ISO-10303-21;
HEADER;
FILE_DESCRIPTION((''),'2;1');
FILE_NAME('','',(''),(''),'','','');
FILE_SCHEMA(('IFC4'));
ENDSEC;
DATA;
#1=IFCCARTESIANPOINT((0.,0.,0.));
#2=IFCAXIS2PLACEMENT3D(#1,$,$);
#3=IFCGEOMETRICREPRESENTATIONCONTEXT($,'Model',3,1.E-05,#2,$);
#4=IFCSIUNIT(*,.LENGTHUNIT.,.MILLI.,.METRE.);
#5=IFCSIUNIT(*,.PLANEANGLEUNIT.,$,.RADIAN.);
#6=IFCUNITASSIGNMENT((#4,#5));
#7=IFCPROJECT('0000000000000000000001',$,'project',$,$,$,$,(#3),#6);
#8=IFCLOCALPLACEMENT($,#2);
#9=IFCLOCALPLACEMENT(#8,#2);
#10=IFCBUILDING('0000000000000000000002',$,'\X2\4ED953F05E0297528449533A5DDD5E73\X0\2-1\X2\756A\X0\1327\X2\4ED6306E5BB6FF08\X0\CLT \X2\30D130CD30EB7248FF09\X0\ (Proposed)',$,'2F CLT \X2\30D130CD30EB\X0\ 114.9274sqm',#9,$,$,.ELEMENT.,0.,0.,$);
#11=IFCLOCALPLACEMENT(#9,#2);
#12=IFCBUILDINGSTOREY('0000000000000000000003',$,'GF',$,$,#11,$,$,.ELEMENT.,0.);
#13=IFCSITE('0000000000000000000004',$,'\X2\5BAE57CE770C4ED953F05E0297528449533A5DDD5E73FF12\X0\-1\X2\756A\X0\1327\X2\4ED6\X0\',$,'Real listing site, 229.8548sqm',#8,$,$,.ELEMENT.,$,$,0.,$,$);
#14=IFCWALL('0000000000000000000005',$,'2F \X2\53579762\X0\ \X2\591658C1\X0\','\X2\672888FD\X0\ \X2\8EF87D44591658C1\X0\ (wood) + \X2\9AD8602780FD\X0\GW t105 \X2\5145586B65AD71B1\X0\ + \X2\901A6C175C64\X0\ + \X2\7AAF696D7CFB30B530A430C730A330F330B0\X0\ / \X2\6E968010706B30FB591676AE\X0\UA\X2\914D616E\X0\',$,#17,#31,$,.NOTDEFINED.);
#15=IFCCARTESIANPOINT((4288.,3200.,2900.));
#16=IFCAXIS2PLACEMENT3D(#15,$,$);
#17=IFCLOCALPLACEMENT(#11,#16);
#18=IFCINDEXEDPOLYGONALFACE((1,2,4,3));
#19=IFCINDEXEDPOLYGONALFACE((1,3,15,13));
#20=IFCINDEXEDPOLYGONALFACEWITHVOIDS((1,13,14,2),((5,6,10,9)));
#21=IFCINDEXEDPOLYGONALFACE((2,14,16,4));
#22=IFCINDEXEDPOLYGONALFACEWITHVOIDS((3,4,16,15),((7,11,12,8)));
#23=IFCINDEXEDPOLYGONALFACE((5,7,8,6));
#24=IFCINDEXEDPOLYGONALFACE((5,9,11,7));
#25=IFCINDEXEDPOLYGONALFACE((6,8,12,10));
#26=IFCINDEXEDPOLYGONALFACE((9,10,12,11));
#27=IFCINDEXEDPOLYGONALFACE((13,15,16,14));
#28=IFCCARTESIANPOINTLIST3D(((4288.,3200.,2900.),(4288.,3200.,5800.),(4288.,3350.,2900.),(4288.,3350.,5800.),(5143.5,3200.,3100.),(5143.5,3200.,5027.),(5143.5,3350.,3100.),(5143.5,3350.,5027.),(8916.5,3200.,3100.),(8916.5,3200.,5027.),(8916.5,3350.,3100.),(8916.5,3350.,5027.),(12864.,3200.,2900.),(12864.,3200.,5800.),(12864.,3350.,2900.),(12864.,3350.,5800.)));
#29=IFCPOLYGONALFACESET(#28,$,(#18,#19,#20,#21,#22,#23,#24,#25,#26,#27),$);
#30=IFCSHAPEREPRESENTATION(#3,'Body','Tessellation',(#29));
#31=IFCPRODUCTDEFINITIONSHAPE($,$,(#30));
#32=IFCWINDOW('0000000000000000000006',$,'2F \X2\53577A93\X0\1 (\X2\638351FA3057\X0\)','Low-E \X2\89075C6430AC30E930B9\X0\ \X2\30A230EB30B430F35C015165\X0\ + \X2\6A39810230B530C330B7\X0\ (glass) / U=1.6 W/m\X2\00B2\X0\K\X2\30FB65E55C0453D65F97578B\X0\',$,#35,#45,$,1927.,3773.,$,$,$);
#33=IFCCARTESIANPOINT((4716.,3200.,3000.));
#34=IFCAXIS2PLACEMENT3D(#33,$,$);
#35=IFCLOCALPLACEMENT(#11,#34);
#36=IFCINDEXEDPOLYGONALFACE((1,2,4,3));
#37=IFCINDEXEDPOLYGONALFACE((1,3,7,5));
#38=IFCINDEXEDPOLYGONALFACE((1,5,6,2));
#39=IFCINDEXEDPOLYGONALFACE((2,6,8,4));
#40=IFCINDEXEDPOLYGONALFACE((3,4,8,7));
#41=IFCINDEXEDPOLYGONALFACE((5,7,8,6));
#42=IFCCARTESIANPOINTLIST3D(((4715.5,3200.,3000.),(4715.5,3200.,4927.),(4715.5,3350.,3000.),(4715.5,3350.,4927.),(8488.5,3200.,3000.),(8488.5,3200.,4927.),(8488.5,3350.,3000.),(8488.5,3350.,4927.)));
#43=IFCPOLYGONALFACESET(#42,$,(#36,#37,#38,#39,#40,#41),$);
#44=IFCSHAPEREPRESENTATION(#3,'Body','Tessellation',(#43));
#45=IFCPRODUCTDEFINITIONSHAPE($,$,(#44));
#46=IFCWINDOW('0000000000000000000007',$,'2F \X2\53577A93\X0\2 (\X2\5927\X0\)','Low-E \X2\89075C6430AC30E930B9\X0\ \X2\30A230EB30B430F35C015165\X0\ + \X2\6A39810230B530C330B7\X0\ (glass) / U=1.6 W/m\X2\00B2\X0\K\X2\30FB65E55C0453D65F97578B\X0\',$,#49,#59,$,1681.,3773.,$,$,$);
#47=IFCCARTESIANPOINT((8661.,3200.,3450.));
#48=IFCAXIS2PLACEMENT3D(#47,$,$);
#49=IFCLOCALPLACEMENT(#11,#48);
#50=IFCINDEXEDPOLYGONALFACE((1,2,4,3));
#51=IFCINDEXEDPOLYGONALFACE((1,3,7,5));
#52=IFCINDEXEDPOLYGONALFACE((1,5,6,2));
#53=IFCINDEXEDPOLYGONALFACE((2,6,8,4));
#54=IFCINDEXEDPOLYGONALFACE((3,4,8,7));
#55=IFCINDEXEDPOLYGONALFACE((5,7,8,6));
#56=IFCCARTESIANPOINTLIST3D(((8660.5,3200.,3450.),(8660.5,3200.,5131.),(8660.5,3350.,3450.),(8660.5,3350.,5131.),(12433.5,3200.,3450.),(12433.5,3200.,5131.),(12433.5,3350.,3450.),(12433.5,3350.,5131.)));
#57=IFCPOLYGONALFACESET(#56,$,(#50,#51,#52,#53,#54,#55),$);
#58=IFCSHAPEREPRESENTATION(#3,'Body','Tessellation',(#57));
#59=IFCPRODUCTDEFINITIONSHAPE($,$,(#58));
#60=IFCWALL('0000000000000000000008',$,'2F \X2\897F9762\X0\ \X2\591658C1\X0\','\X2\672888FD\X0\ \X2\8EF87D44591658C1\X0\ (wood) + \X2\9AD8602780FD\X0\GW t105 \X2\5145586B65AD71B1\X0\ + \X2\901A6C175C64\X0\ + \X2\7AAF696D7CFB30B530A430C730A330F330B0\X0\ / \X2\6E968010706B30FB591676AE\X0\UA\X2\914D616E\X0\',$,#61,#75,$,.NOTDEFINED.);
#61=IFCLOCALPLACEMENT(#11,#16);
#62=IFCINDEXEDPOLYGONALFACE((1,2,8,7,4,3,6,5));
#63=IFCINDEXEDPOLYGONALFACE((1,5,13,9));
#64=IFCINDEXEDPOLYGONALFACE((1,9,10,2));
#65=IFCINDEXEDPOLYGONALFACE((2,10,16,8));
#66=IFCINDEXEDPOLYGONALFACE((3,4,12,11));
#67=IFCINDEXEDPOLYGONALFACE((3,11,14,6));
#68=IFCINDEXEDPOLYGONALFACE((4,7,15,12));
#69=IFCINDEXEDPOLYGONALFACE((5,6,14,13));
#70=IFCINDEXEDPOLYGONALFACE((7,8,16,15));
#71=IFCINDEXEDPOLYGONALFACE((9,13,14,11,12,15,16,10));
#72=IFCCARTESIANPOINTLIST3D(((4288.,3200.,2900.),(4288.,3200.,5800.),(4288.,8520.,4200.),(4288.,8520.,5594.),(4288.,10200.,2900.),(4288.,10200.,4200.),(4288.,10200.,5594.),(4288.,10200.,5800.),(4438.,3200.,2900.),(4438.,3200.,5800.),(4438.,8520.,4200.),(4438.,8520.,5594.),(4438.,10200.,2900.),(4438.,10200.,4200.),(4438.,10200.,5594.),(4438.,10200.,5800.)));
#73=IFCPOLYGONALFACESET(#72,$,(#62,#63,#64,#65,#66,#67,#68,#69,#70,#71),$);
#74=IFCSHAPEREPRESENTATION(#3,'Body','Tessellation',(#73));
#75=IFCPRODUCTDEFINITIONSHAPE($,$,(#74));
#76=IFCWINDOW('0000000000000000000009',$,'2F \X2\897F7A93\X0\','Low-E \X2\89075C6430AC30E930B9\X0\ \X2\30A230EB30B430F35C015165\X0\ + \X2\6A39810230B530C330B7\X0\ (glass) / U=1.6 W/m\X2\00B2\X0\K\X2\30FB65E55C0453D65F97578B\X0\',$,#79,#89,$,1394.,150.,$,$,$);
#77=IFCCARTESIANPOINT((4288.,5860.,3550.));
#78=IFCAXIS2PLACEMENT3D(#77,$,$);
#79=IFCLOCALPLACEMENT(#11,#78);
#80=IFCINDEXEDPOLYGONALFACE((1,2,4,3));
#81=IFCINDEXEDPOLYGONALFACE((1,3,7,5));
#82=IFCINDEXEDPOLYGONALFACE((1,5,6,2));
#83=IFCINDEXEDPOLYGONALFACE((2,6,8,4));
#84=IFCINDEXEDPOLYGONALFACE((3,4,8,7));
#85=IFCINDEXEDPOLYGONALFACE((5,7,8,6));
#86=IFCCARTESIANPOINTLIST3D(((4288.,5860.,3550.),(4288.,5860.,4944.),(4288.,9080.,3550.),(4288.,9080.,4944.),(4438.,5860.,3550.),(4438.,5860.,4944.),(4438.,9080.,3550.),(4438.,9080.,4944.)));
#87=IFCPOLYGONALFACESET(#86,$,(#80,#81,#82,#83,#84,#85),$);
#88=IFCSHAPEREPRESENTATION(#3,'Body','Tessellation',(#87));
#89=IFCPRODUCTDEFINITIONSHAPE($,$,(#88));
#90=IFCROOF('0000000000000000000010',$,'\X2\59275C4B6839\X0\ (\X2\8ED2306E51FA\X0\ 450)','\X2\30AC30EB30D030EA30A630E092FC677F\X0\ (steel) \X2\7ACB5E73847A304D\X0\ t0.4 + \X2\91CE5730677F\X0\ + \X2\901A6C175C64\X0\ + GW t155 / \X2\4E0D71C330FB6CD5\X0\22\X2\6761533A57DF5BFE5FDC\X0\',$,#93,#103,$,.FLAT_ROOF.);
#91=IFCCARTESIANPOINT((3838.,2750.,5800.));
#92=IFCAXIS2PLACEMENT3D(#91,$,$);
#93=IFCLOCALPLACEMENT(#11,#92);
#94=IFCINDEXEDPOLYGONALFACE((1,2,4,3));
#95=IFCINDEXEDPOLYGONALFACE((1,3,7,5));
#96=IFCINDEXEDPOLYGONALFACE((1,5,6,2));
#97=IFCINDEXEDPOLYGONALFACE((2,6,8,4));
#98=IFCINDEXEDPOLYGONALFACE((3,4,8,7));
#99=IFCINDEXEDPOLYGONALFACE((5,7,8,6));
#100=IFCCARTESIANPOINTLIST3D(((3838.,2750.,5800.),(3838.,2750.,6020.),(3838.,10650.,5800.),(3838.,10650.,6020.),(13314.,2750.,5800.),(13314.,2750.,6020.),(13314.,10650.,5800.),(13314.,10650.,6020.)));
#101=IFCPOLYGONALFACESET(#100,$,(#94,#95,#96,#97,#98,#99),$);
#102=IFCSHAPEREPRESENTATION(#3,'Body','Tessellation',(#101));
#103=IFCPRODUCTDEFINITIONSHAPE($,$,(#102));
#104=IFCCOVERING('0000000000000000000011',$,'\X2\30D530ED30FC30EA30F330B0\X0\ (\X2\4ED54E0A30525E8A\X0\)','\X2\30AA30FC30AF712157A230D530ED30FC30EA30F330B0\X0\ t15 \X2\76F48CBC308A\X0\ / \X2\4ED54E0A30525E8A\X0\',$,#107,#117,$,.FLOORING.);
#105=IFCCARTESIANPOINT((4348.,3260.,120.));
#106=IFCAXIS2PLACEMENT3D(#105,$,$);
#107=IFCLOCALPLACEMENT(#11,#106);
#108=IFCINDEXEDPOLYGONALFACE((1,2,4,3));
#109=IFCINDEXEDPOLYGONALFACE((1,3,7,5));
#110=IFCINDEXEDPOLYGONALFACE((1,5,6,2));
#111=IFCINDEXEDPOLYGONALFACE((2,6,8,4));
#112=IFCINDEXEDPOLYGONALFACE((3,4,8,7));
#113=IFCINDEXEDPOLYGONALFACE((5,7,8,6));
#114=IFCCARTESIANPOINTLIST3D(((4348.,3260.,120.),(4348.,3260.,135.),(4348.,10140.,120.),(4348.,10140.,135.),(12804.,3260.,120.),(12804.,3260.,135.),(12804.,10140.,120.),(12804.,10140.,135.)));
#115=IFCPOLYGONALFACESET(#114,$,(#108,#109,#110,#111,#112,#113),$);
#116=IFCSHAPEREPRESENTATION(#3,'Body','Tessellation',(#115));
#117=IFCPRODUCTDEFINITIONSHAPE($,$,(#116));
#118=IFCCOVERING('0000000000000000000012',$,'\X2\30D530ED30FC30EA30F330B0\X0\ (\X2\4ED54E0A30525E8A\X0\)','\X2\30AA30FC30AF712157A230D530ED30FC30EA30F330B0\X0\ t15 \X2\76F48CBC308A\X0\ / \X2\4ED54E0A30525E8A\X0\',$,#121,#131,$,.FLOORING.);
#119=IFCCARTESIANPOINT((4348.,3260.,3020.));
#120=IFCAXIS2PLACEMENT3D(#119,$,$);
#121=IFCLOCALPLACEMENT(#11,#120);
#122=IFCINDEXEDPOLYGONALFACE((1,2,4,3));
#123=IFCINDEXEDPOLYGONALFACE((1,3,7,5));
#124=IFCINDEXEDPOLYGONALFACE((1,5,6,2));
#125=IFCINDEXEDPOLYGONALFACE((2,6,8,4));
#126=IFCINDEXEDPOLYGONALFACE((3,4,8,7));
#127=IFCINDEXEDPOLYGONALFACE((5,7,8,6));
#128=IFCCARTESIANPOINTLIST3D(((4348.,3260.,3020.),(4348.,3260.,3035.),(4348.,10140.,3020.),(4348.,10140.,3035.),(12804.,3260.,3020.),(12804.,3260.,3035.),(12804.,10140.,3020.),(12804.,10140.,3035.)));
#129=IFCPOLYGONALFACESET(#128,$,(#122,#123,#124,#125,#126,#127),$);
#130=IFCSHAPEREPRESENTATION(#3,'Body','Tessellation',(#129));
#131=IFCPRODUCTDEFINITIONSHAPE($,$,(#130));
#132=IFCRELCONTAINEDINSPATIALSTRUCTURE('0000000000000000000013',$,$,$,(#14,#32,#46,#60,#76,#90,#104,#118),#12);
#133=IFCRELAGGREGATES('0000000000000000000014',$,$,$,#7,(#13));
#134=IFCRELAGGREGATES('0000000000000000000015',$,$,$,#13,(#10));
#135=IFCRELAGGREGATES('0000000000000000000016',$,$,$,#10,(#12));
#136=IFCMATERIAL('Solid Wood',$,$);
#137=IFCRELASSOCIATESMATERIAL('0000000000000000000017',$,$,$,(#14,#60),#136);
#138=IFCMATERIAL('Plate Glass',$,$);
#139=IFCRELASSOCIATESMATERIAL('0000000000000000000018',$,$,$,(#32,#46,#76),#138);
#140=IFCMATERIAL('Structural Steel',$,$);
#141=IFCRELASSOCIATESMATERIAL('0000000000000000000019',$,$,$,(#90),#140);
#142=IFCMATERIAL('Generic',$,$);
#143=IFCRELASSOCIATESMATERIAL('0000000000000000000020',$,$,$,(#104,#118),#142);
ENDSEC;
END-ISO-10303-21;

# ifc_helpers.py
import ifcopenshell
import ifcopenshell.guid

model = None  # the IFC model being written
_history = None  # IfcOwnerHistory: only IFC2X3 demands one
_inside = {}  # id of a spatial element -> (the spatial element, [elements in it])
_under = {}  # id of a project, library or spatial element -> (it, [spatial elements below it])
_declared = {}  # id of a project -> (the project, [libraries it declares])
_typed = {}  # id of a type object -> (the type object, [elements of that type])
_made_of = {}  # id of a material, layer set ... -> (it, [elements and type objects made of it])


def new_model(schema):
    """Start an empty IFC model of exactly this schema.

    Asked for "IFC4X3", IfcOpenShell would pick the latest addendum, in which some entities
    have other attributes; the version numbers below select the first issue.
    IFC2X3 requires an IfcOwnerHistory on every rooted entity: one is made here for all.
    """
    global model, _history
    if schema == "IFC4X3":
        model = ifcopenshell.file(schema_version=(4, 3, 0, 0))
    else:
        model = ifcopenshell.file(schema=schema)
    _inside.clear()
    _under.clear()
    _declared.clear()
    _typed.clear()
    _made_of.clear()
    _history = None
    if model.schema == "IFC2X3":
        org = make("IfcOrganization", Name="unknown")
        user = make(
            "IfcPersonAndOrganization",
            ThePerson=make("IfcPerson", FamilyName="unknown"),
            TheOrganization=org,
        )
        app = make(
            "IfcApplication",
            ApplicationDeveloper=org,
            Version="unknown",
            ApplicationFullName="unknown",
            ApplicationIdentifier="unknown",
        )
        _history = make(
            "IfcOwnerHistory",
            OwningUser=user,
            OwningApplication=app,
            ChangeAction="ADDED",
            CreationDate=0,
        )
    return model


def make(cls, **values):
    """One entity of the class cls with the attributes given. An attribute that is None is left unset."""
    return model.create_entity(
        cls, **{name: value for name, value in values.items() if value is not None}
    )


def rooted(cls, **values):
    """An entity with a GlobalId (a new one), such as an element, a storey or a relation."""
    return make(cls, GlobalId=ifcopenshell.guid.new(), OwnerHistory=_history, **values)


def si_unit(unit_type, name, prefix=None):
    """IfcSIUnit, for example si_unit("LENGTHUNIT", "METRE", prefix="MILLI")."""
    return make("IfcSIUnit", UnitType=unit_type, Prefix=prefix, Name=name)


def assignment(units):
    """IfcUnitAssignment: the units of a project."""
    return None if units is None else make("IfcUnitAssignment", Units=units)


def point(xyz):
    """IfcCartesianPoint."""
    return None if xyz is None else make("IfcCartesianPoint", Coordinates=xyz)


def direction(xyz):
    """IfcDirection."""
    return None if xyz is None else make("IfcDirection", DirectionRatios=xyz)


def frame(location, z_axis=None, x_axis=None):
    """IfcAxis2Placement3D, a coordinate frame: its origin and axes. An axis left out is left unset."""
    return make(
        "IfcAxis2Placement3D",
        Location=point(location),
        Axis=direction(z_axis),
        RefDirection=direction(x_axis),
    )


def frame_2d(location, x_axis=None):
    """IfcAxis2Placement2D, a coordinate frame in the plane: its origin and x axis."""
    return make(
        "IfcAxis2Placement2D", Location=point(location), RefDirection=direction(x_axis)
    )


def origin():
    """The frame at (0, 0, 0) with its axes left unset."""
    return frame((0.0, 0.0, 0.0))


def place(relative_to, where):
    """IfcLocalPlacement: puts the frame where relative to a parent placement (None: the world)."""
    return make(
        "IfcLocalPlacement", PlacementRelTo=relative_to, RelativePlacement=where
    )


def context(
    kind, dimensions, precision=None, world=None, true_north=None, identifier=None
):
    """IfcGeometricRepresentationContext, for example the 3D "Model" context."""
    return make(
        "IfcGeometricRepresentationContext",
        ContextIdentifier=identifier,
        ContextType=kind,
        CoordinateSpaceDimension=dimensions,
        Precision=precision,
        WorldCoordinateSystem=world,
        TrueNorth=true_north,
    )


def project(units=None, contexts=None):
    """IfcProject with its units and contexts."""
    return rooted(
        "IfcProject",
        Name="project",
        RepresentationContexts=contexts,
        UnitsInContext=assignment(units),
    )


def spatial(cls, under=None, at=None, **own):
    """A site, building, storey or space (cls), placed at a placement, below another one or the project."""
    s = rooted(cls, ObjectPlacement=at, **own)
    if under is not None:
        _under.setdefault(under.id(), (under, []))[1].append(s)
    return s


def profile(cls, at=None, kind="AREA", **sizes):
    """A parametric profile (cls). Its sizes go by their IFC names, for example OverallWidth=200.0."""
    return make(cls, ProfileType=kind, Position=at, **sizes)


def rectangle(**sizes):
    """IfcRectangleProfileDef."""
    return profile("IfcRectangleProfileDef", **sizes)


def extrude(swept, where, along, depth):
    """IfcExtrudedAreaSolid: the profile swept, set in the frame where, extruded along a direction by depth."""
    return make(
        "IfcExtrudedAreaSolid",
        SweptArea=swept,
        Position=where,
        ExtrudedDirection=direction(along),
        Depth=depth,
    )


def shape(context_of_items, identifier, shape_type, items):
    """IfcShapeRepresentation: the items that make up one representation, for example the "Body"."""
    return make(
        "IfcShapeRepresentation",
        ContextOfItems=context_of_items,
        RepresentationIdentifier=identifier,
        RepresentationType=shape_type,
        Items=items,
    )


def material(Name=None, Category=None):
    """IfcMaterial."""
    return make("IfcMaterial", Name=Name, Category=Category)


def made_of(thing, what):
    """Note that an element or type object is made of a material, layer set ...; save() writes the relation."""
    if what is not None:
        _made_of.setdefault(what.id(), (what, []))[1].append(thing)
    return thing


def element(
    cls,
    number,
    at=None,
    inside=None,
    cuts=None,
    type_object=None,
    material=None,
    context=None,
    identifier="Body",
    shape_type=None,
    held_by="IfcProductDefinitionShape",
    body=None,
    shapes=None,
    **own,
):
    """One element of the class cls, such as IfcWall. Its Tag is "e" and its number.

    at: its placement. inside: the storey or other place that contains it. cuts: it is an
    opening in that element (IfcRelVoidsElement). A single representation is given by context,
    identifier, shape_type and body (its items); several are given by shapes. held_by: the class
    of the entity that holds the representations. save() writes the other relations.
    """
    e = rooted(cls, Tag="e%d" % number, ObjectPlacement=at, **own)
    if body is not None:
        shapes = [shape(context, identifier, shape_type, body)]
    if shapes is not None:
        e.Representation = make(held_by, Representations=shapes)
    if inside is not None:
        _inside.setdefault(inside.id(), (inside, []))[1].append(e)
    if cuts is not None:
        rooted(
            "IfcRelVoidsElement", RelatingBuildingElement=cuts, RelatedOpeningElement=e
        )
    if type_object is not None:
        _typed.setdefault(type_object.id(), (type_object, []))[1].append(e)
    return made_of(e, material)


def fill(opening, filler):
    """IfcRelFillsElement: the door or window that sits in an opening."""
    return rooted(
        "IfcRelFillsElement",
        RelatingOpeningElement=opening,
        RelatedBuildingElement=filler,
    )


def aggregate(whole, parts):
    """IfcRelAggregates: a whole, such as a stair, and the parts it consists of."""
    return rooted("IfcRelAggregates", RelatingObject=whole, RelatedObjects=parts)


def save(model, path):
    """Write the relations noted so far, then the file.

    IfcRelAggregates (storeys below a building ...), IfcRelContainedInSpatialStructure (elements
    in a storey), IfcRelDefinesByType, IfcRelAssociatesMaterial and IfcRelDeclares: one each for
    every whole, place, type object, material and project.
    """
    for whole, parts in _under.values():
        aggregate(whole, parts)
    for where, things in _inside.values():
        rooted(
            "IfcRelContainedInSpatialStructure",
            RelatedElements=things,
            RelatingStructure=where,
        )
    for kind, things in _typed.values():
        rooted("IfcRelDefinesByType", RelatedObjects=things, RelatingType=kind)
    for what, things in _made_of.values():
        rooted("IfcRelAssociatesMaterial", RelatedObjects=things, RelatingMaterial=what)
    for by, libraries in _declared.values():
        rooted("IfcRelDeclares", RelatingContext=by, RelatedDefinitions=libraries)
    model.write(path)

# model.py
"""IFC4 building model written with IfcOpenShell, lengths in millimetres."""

from ifc_helpers import new_model, si_unit, frame, frame_2d, origin, place, context, project, spatial, rectangle, extrude, material, element, fill, save


model = new_model("IFC4")

# Units and contexts
model_context = context("Model", 3, precision=1e-05, world=origin())
ifc_project = project(units=[si_unit("LENGTHUNIT", "METRE", prefix="MILLI"), si_unit("PLANEANGLEUNIT", "RADIAN")], contexts=[model_context])

# Site, building, storey
site_placement = place(None, origin())
site = spatial("IfcSite", under=ifc_project, at=site_placement, Name="宮城県仙台市青葉区川平２-1番1327他", ObjectType="Real listing site, 229.8548sqm", CompositionType="ELEMENT", RefElevation=0.0)
building_placement = place(site_placement, origin())
building = spatial("IfcBuilding", under=site, at=building_placement, Name="仙台市青葉区川平2-1番1327他の家（CLT パネル版） (Proposed)", ObjectType="2F CLT パネル 114.9274sqm", CompositionType="ELEMENT", ElevationOfRefHeight=0.0, ElevationOfTerrain=0.0)
storey_placement = place(building_placement, origin())
storey = spatial("IfcBuildingStorey", under=building, at=storey_placement, Name="GF", CompositionType="ELEMENT", Elevation=0.0)

# Shared definitions
ifc_material_1 = material(Name="Solid Wood")

# Shared definitions
ifc_material_2 = material(Name="Plate Glass")

# Wall, openings, windows
wall_1_placement = place(storey_placement, frame((4288.0, 3200.0, 2900.0)))
wall_1 = element("IfcWall", 1, at=wall_1_placement, inside=storey, material=ifc_material_1, Name="2F 南面 外壁", Description="木製 軸組外壁 (wood) + 高性能GW t105 充填断熱 + 通気層 + 窯業系サイディング / 準耐火・外皮UA配慮", PredefinedType="NOTDEFINED", context=model_context, shape_type="SweptSolid", body=[
    extrude(rectangle(XDim=8576.0, YDim=150.0, at=frame_2d((4288.0, 75.0))), frame((4288.0, 3200.0, 2900.0)), (0.0, 0.0, 1.0), 2900.0),
])
opening_1_placement = place(storey_placement, frame((4716.0, 3200.0, 3000.0)))
opening_1 = element("IfcOpeningElement", 2, at=opening_1_placement, cuts=wall_1, PredefinedType="NOTDEFINED", context=model_context, shape_type="SweptSolid", body=[
    extrude(rectangle(XDim=3773.0, YDim=150.0, at=frame_2d((1886.0, 75.0))), frame((4716.0, 3200.0, 3000.0)), (0.0, 0.0, 1.0), 1927.0),
])
opening_2_placement = place(storey_placement, frame((8661.0, 3200.0, 3450.0)))
opening_2 = element("IfcOpeningElement", 3, at=opening_2_placement, cuts=wall_1, PredefinedType="NOTDEFINED", context=model_context, shape_type="SweptSolid", body=[
    extrude(rectangle(XDim=3773.0, YDim=150.0, at=frame_2d((1886.0, 75.0))), frame((8661.0, 3200.0, 3450.0)), (0.0, 0.0, 1.0), 1681.0),
])
window_1_placement = place(storey_placement, frame((4716.0, 3200.0, 3000.0)))
window_1 = element("IfcWindow", 4, at=window_1_placement, inside=storey, material=ifc_material_2, Name="2F 南窓1 (掃出し)", Description="Low-E 複層ガラス アルゴン封入 + 樹脂サッシ (glass) / U=1.6 W/m²K・日射取得型", OverallHeight=1927.0, OverallWidth=3773.0, context=model_context, shape_type="SweptSolid", body=[
    extrude(rectangle(XDim=3773.0, YDim=150.0, at=frame_2d((1886.0, 75.0))), frame((4716.0, 3200.0, 3000.0)), (0.0, 0.0, 1.0), 1927.0),
])
fill(opening_1, window_1)
window_2_placement = place(storey_placement, frame((8661.0, 3200.0, 3450.0)))
window_2 = element("IfcWindow", 5, at=window_2_placement, inside=storey, material=ifc_material_2, Name="2F 南窓2 (大)", Description="Low-E 複層ガラス アルゴン封入 + 樹脂サッシ (glass) / U=1.6 W/m²K・日射取得型", OverallHeight=1681.0, OverallWidth=3773.0, context=model_context, shape_type="SweptSolid", body=[
    extrude(rectangle(XDim=3773.0, YDim=150.0, at=frame_2d((1886.0, 75.0))), frame((8661.0, 3200.0, 3450.0)), (0.0, 0.0, 1.0), 1681.0),
])
fill(opening_2, window_2)

# Wall, opening, window
wall_2_placement = place(storey_placement, frame((4288.0, 3200.0, 2900.0)))
wall_2 = element("IfcWall", 6, at=wall_2_placement, inside=storey, material=ifc_material_1, Name="2F 西面 外壁", Description="木製 軸組外壁 (wood) + 高性能GW t105 充填断熱 + 通気層 + 窯業系サイディング / 準耐火・外皮UA配慮", PredefinedType="NOTDEFINED", context=model_context, shape_type="SweptSolid", body=[
    extrude(rectangle(XDim=150.0, YDim=7000.0, at=frame_2d((75.0, 3500.0))), frame((4288.0, 3200.0, 2900.0)), (0.0, 0.0, 1.0), 2900.0),
])
opening_3_placement = place(storey_placement, frame((4288.0, 5860.0, 3550.0)))
opening_3 = element("IfcOpeningElement", 7, at=opening_3_placement, cuts=wall_2, PredefinedType="NOTDEFINED", context=model_context, shape_type="SweptSolid", body=[
    extrude(rectangle(XDim=150.0, YDim=3220.0, at=frame_2d((75.0, 1610.0))), frame((4288.0, 5860.0, 3550.0)), (0.0, 0.0, 1.0), 1394.0),
])
window_3_placement = place(storey_placement, frame((4288.0, 5860.0, 3550.0)))
window_3 = element("IfcWindow", 8, at=window_3_placement, inside=storey, material=ifc_material_2, Name="2F 西窓", Description="Low-E 複層ガラス アルゴン封入 + 樹脂サッシ (glass) / U=1.6 W/m²K・日射取得型", OverallHeight=1394.0, OverallWidth=150.0, context=model_context, shape_type="SweptSolid", body=[
    extrude(rectangle(XDim=150.0, YDim=3220.0, at=frame_2d((75.0, 1610.0))), frame((4288.0, 5860.0, 3550.0)), (0.0, 0.0, 1.0), 1394.0),
])
fill(opening_3, window_3)

# Roof
ifc_material_3 = material(Name="Structural Steel")
roof_placement = place(storey_placement, frame((3838.0, 2750.0, 5800.0)))
element("IfcRoof", 9, at=roof_placement, inside=storey, material=ifc_material_3, Name="大屋根 (軒の出 450)", Description="ガルバリウム鋼板 (steel) 立平葺き t0.4 + 野地板 + 通気層 + GW t155 / 不燃・法22条区域対応", PredefinedType="FLAT_ROOF", context=model_context, shape_type="SweptSolid", body=[
    extrude(rectangle(XDim=9476.0, YDim=7900.0, at=frame_2d((4738.0, 3950.0))), frame((3838.0, 2750.0, 5800.0)), (0.0, 0.0, 1.0), 220.0),
])

# Coverings
ifc_material_4 = material(Name="Generic")
covering_1_placement = place(storey_placement, frame((4348.0, 3260.0, 120.0)))
element("IfcCovering", 10, at=covering_1_placement, inside=storey, material=ifc_material_4, Name="フローリング (仕上げ床)", Description="オーク無垢フローリング t15 直貼り / 仕上げ床", PredefinedType="FLOORING", context=model_context, shape_type="SweptSolid", body=[
    extrude(rectangle(XDim=8456.0, YDim=6880.0, at=frame_2d((4228.0, 3440.0))), frame((4348.0, 3260.0, 120.0)), (0.0, 0.0, 1.0), 15.0),
])
covering_2_placement = place(storey_placement, frame((4348.0, 3260.0, 3020.0)))
element("IfcCovering", 11, at=covering_2_placement, inside=storey, material=ifc_material_4, Name="フローリング (仕上げ床)", Description="オーク無垢フローリング t15 直貼り / 仕上げ床", PredefinedType="FLOORING", context=model_context, shape_type="SweptSolid", body=[
    extrude(rectangle(XDim=8456.0, YDim=6880.0, at=frame_2d((4228.0, 3440.0))), frame((4348.0, 3260.0, 3020.0)), (0.0, 0.0, 1.0), 15.0),
])

save(model, "model.ifc")
